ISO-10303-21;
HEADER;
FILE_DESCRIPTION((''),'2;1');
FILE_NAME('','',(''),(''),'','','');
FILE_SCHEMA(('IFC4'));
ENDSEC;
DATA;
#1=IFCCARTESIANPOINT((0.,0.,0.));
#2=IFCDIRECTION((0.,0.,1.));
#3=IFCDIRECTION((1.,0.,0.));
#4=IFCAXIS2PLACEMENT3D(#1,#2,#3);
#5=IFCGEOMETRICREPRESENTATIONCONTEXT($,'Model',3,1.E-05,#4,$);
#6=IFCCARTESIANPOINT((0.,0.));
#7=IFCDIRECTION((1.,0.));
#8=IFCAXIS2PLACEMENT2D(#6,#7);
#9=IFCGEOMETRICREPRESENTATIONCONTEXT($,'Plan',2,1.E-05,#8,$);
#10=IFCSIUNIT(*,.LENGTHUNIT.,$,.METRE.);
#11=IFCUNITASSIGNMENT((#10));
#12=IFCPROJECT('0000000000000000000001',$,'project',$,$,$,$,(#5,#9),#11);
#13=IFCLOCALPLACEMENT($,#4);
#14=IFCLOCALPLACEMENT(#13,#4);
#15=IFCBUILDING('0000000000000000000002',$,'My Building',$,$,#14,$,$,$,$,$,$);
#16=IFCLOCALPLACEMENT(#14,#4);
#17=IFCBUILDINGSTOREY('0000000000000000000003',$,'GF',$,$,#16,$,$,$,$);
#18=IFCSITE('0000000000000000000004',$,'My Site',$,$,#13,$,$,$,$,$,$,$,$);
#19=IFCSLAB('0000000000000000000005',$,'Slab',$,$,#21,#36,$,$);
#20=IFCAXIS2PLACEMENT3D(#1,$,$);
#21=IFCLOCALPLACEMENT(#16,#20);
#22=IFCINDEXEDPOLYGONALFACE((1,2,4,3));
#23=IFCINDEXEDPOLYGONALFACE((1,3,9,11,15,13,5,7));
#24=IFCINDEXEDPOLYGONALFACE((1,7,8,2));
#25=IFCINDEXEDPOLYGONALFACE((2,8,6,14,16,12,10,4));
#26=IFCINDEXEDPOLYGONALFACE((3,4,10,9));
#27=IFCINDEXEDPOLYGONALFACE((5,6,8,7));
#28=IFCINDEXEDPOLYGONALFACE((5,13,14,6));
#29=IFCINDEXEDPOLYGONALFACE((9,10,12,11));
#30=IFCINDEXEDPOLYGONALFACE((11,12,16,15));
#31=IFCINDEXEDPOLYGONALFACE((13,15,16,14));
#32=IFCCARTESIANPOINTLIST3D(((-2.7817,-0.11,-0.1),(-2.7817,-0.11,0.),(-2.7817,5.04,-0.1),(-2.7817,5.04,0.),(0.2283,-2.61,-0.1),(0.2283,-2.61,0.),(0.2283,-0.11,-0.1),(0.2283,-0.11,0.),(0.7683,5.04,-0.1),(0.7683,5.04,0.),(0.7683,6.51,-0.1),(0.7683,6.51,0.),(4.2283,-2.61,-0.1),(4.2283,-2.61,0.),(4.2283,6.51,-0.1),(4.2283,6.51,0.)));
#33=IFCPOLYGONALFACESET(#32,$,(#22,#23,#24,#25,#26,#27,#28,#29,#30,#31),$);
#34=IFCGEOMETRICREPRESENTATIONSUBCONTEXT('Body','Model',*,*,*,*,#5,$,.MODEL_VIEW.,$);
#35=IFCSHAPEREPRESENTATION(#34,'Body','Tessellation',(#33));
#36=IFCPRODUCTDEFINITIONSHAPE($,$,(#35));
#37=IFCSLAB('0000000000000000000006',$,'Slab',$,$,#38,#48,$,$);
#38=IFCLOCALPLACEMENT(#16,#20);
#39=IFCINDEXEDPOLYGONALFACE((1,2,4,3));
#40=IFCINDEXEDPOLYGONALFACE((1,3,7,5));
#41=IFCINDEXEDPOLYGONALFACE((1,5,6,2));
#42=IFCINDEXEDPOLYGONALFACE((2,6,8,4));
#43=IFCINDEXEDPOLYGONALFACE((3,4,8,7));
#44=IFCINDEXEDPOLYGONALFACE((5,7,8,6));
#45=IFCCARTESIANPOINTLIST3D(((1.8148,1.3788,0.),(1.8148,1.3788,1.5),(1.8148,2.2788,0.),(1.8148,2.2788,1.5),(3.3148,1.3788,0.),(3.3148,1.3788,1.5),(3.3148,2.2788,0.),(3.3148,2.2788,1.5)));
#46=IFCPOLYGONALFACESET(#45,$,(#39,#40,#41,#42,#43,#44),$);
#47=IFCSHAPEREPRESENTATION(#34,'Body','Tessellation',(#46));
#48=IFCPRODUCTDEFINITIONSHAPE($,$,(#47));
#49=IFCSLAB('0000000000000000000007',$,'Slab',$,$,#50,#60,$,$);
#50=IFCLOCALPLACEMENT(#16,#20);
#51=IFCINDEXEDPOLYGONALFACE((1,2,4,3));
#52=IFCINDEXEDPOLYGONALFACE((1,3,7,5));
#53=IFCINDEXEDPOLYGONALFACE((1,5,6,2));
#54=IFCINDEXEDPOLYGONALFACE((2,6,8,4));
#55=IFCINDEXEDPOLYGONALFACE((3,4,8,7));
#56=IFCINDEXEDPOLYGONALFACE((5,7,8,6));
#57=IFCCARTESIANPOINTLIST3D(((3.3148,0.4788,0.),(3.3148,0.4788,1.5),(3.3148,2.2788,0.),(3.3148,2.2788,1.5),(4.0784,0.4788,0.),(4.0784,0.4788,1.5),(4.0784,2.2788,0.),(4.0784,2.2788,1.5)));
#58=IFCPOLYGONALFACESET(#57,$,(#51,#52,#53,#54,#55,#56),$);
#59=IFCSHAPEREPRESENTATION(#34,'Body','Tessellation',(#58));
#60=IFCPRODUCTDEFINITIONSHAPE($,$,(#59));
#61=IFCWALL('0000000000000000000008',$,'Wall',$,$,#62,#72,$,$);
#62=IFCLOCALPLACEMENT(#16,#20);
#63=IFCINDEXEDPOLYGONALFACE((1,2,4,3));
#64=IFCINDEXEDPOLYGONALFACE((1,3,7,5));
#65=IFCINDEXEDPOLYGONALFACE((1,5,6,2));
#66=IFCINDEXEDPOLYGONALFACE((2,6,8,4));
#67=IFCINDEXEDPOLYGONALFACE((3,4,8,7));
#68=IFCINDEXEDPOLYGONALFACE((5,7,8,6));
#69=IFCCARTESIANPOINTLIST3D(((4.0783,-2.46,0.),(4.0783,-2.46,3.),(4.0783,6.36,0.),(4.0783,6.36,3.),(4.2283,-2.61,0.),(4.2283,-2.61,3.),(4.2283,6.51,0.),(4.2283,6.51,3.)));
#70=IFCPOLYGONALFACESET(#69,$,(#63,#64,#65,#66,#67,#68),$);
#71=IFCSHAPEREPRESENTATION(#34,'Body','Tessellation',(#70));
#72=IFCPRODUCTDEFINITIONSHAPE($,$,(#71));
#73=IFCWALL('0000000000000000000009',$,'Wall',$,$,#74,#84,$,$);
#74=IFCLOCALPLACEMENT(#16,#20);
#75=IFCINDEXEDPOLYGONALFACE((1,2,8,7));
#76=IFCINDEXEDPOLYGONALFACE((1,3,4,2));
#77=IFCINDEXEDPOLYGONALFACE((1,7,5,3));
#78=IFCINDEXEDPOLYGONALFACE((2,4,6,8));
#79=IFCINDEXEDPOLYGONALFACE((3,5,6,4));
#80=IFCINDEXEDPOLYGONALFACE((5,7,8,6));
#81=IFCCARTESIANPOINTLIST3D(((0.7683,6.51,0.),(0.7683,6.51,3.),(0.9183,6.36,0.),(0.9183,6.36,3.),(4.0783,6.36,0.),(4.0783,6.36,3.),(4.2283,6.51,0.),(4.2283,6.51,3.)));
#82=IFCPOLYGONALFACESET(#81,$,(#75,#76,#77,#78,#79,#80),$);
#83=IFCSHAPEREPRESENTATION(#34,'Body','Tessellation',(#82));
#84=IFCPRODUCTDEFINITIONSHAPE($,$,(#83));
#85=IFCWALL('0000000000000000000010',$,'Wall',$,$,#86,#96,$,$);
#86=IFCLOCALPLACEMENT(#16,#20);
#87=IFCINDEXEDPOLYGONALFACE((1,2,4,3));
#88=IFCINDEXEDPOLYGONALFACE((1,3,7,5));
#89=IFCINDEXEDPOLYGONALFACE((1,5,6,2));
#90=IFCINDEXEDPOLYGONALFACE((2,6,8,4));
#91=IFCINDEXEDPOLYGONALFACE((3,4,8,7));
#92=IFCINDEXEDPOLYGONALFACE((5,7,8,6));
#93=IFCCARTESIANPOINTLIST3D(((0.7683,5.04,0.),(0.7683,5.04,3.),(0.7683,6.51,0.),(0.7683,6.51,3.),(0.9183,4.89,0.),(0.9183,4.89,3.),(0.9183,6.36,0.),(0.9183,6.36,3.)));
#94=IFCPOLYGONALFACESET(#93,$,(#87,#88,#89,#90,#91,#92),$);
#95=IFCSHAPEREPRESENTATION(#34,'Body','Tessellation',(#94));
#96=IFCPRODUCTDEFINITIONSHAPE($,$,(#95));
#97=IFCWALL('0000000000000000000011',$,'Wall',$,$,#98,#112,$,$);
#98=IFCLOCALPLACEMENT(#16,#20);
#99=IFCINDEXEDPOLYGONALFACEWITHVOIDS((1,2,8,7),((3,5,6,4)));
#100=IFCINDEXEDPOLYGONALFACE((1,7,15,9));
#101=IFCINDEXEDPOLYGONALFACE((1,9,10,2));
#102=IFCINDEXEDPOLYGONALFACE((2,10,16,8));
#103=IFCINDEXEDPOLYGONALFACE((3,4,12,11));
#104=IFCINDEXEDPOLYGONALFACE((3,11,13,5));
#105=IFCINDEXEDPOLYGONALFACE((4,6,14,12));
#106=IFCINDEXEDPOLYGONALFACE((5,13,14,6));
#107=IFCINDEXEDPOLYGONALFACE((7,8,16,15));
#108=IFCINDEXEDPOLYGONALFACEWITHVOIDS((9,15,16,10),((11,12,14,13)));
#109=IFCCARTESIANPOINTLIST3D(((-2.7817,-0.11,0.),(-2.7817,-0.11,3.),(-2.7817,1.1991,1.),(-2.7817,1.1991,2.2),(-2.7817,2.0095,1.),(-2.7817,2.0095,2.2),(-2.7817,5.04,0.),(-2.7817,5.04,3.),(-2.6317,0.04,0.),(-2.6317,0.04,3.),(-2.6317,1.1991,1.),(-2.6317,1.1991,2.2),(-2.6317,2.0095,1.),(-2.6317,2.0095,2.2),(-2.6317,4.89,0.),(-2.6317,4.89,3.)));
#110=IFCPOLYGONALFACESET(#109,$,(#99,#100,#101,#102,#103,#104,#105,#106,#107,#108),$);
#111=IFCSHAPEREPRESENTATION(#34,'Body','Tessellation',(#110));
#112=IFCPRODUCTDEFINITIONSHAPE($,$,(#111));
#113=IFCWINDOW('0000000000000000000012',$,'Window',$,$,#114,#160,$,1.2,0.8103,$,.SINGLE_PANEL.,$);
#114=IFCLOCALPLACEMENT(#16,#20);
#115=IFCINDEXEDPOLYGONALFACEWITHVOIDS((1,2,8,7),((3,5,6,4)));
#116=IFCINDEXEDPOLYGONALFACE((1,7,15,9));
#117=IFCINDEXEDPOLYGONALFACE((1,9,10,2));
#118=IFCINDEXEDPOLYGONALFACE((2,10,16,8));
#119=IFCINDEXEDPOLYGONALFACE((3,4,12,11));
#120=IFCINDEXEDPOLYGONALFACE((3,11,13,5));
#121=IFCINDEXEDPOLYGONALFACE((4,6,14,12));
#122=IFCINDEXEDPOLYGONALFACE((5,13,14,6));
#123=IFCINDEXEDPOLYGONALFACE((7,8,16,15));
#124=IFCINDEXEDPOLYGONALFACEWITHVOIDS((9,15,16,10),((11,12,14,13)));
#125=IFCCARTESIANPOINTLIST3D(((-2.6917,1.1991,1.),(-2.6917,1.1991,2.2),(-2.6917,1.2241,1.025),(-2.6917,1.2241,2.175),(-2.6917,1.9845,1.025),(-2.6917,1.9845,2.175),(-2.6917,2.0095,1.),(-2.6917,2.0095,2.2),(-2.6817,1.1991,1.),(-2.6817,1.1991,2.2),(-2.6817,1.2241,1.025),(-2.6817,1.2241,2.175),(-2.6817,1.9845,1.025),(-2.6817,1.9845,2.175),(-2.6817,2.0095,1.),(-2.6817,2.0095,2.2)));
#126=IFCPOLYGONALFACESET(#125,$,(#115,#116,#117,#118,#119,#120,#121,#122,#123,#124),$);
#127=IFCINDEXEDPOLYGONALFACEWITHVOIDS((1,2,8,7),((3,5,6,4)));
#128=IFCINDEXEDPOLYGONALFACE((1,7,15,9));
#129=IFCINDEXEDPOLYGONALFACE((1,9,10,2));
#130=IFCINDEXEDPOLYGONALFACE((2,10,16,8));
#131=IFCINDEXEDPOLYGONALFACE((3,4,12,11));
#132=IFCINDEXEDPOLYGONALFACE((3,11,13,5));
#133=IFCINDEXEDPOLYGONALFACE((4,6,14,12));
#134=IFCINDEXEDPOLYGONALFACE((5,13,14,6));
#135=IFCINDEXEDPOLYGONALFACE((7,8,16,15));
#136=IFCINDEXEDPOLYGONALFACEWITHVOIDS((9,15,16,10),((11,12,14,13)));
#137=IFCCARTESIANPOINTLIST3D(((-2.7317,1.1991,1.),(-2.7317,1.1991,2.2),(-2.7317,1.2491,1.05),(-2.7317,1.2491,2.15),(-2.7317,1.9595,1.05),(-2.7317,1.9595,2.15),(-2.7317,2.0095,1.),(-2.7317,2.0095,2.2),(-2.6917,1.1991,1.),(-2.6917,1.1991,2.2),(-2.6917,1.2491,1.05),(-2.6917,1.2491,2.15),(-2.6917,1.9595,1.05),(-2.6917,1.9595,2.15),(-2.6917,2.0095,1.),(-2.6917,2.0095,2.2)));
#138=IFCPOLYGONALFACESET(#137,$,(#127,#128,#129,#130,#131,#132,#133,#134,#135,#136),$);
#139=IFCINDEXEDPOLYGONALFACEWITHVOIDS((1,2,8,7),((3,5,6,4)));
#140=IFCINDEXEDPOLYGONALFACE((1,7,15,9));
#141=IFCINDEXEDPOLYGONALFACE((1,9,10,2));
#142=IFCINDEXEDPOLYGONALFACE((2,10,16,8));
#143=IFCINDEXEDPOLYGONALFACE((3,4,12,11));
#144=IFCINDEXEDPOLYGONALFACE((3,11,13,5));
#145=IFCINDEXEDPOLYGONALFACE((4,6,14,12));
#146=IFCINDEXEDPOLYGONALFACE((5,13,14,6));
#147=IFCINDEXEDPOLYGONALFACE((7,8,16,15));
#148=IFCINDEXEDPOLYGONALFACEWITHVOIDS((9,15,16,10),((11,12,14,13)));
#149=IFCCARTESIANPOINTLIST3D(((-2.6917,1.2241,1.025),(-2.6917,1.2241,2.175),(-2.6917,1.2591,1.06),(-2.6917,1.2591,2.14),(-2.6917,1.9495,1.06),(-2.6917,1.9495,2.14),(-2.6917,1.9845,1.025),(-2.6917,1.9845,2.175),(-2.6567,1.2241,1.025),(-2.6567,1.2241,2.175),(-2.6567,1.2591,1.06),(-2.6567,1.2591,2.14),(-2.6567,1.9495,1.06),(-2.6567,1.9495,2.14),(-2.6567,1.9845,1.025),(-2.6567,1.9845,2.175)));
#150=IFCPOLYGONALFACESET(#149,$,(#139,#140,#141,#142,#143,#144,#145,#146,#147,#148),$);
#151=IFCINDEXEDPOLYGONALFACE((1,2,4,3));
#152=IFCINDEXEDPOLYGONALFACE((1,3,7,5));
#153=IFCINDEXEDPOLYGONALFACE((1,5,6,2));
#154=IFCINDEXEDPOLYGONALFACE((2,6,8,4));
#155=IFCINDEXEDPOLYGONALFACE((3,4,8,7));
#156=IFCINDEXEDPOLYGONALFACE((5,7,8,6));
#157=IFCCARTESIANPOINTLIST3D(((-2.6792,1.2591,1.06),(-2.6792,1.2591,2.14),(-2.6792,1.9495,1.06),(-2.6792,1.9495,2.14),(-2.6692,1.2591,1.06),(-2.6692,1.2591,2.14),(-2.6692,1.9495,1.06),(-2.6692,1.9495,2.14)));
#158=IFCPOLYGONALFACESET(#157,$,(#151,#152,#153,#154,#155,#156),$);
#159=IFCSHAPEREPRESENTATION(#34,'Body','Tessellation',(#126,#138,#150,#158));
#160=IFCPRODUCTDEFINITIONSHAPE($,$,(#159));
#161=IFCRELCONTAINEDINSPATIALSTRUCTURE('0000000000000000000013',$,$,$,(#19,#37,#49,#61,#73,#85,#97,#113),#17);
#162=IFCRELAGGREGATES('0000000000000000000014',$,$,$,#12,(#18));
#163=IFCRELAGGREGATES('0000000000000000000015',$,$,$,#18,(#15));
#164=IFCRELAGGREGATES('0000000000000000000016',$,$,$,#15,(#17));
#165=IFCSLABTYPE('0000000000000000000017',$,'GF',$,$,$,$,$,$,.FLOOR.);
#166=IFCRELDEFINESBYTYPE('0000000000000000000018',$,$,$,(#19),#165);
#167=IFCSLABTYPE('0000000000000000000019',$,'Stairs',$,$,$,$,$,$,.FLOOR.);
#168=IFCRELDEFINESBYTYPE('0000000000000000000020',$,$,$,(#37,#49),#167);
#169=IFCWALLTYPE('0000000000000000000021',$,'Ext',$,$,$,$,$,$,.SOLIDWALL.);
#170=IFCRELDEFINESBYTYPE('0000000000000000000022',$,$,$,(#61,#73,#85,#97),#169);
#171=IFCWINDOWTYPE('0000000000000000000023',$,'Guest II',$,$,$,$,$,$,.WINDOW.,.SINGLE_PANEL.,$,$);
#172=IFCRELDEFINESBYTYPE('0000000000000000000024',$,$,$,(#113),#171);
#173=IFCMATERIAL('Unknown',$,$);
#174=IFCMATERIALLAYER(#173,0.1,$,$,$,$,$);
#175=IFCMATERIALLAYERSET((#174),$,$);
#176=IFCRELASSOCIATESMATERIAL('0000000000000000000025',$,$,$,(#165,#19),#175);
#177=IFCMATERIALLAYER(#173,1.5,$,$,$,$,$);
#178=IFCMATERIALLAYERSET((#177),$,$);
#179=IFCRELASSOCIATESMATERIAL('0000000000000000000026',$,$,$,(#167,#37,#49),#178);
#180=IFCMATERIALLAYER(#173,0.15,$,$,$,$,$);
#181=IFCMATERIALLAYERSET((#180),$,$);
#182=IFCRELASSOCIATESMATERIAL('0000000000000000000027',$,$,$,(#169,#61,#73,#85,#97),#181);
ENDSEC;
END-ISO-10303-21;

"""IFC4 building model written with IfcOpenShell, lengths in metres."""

from ifc_helpers import new_model, entity, si_unit, frame, origin_with_axes, origin_2d_with_axis, place, context, subcontext, project, spatial, line, indexed_curve, outline, extrude, shape, source, transform, mapped, material, layer, layer_set, layer_usage, type_object, type_shapes, element, fill, save


model = new_model("IFC4")

# Units and contexts
model_context = context("Model", 3, precision=1e-05, world=origin_with_axes())
plan_context = context("Plan", 2, precision=1e-05, world=origin_2d_with_axis())
body_context_1 = subcontext(model_context, "Body", "Model", "MODEL_VIEW")
body_context_2 = subcontext(plan_context, "Body", "Plan", "PLAN_VIEW")
ifc_project = project(units=[si_unit("LENGTHUNIT", "METRE")], contexts=[model_context, plan_context])

# Site, building, storey
site_placement = place(None, origin_with_axes())
site = spatial("IfcSite", under=ifc_project, at=site_placement, Name="My Site")
building_placement = place(site_placement, origin_with_axes())
building = spatial("IfcBuilding", under=site, at=building_placement, Name="My Building")
storey_placement = place(building_placement, origin_with_axes())
storey = spatial("IfcBuildingStorey", under=building, at=storey_placement, Name="GF")

# Slabs
ifc_material = material(Name="Unknown")
ifc_layer_1 = layer(ifc_material, 0.1)
ifc_layer_set_1 = layer_set([ifc_layer_1])
ifc_layer_usage_1 = layer_usage(ifc_layer_set_1, "AXIS3", "POSITIVE", -0.1)
slab_type_1 = type_object("IfcSlabType", Name="GF", PredefinedType="FLOOR", material=ifc_layer_set_1)
slab_1_placement = place(storey_placement, frame((-2.7817, 5.04, 0.0), z_axis=(0.0, 0.0, 1.0), x_axis=(1.0, 0.0, 0.0)))
element("IfcSlab", 1, at=slab_1_placement, inside=storey, type_object=slab_type_1, material=ifc_layer_usage_1, Name="Slab", context=body_context_1, shape_type="SweptSolid", body=[
    extrude(outline(indexed_curve([(0.0, 0.0), (3.55, 0.0), (3.55, 1.47), (7.01, 1.47), (7.01, -7.65), (3.01, -7.65), (3.01, -5.15), (0.0, -5.15), (0.0, 0.0)])), frame((0.0, 0.0, -0.1), z_axis=(0.0, 0.0, 1.0), x_axis=(1.0, 0.0, 0.0)), (0.0, 0.0, 1.0), 0.1),
])
ifc_layer_2 = layer(ifc_material, 1.5)
ifc_layer_set_2 = layer_set([ifc_layer_2])
ifc_layer_usage_2 = layer_usage(ifc_layer_set_2, "AXIS3", "POSITIVE", -1.5)
slab_type_2 = type_object("IfcSlabType", Name="Stairs", PredefinedType="FLOOR", material=ifc_layer_set_2)
slab_2_placement = place(storey_placement, frame((3.3148, 2.2788, 1.5), z_axis=(0.0, 0.0, 1.0), x_axis=(1.0, 0.0, 0.0)))
element("IfcSlab", 2, at=slab_2_placement, inside=storey, type_object=slab_type_2, material=ifc_layer_usage_2, Name="Slab", context=body_context_1, shape_type="SweptSolid", body=[
    extrude(outline(indexed_curve([(0.0, 0.0), (0.0, -0.9), (-1.5, -0.9), (-1.5, 0.0), (0.0, 0.0)])), frame((0.0, 0.0, -1.5), z_axis=(0.0, 0.0, 1.0), x_axis=(1.0, 0.0, 0.0)), (0.0, 0.0, 1.0), 1.5),
])
ifc_layer_usage_3 = layer_usage(ifc_layer_set_2, "AXIS3", "POSITIVE", -1.5)
slab_3_placement = place(storey_placement, frame((3.3148, 0.4788, 1.5), z_axis=(0.0, 0.0, 1.0), x_axis=(1.0, 0.0, 0.0)))
element("IfcSlab", 3, at=slab_3_placement, inside=storey, type_object=slab_type_2, material=ifc_layer_usage_3, Name="Slab", context=body_context_1, shape_type="SweptSolid", body=[
    extrude(outline(indexed_curve([(0.0, 0.0), (0.7636, 0.0), (0.7636, 1.8), (0.0, 1.8), (0.0, 0.0)])), frame((0.0, 0.0, -1.5), z_axis=(0.0, 0.0, 1.0), x_axis=(1.0, 0.0, 0.0)), (0.0, 0.0, 1.0), 1.5),
])

# Shared definitions
ifc_layer_3 = layer(ifc_material, 0.15)
ifc_layer_set_3 = layer_set([ifc_layer_3])
wall_type_1 = type_object("IfcWallType", Name="Ext", PredefinedType="SOLIDWALL", material=ifc_layer_set_3)

# Walls
ifc_layer_usage_4 = layer_usage(ifc_layer_set_3, "AXIS2", "POSITIVE", 0.0)
wall_1_placement = place(storey_placement, frame((4.2283, -2.61, 0.0), z_axis=(0.0, 0.0, 1.0), x_axis=(0.0, 1.0, 0.0)))
element("IfcWall", 4, at=wall_1_placement, inside=storey, type_object=wall_type_1, material=ifc_layer_usage_4, Name="Wall", context=body_context_1, shape_type="SweptSolid", body=[
    extrude(outline(indexed_curve([(0.0, 0.0), (0.15, 0.15), (8.97, 0.15), (9.12, 0.0)], segments=[line(1, 2, 3, 4, 1)])), origin_with_axes(), (0.0, 0.0, 1.0), 3.0),
])
ifc_layer_usage_5 = layer_usage(ifc_layer_set_3, "AXIS2", "POSITIVE", 0.0)
wall_2_placement = place(storey_placement, frame((4.2283, 6.51, 0.0), z_axis=(0.0, 0.0, 1.0), x_axis=(-1.0, 0.0, 0.0)))
element("IfcWall", 5, at=wall_2_placement, inside=storey, type_object=wall_type_1, material=ifc_layer_usage_5, Name="Wall", context=body_context_1, shape_type="SweptSolid", body=[
    extrude(outline(indexed_curve([(0.0, 0.0), (0.15, 0.15), (3.31, 0.15), (3.46, 0.0)], segments=[line(1, 2, 3, 4, 1)])), origin_with_axes(), (0.0, 0.0, 1.0), 3.0),
])
ifc_layer_usage_6 = layer_usage(ifc_layer_set_3, "AXIS2", "POSITIVE", 0.0)
wall_3_placement = place(storey_placement, frame((0.7683, 6.51, 0.0), z_axis=(0.0, 0.0, 1.0), x_axis=(0.0, -1.0, 0.0)))
element("IfcWall", 6, at=wall_3_placement, inside=storey, type_object=wall_type_1, material=ifc_layer_usage_6, Name="Wall", context=body_context_1, shape_type="SweptSolid", body=[
    extrude(outline(indexed_curve([(0.0, 0.0), (0.15, 0.15), (1.62, 0.15), (1.47, 0.0)], segments=[line(1, 2, 3, 4, 1)])), origin_with_axes(), (0.0, 0.0, 1.0), 3.0),
])

# Wall, opening, window
ifc_layer_usage_7 = layer_usage(ifc_layer_set_3, "AXIS2", "POSITIVE", 0.0)
wall_4_placement = place(storey_placement, frame((-2.7817, 5.04, 0.0), z_axis=(0.0, 0.0, 1.0), x_axis=(0.0, -1.0, 0.0)))
wall_4 = element("IfcWall", 7, at=wall_4_placement, inside=storey, type_object=wall_type_1, material=ifc_layer_usage_7, Name="Wall", context=body_context_1, shape_type="SweptSolid", body=[
    extrude(outline(indexed_curve([(0.0, 0.0), (0.15, 0.15), (5.0, 0.15), (5.15, 0.0)], segments=[line(1, 2, 3, 4, 1)])), origin_with_axes(), (0.0, 0.0, 1.0), 3.0),
])
shared_shape_1 = source(origin_with_axes(), body_context_1, "Body", "SweptSolid", [
    extrude(outline(indexed_curve([(0.0, 0.0), (0.8103, 0.0), (0.8103, 1.2), (0.0, 1.2)], segments=[line(1, 2, 3, 4, 1)])), frame((0.0, -0.6, 0.0), z_axis=(0.0, -1.0, 0.0), x_axis=(1.0, 0.0, 0.0)), (0.0, 0.0, -1.0), 1.2),
])
opening_1_placement = place(wall_4_placement, frame((3.0305, 0.0, 1.0), z_axis=(0.0, 0.0, 1.0), x_axis=(1.0, 0.0, 0.0)))
opening_1 = element("IfcOpeningElement", 8, at=opening_1_placement, cuts=wall_4, PredefinedType="OPENING", context=body_context_1, shape_type="MappedRepresentation", body=[
    mapped(shared_shape_1, transform((0.0, 0.0, 0.0), x_axis=(1.0, 0.0, 0.0), y_axis=(0.0, 1.0, 0.0), z_axis=(0.0, 0.0, 1.0), scale=1.0)),
])
window_type_1 = type_object("IfcWindowType", Name="Guest II", PartitioningType="SINGLE_PANEL", PredefinedType="WINDOW")
shared_shape_2 = source(origin_with_axes(), body_context_1, "Body", "SweptSolid", [
    extrude(outline(indexed_curve([(0.0, 0.0), (0.8103, 0.0), (0.8103, 1.2), (0.0, 1.2)], segments=[line(1, 2, 3, 4, 1)]), holes=[indexed_curve([(0.025, 0.025), (0.7853, 0.025), (0.7853, 1.175), (0.025, 1.175)], segments=[line(1, 2, 3, 4, 1)])]), frame((0.0, 0.09, 0.0), z_axis=(0.0, -1.0, 0.0), x_axis=(1.0, 0.0, 0.0)), (0.0, 0.0, -1.0), 0.01),
    extrude(outline(indexed_curve([(0.0, 0.0), (0.8103, 0.0), (0.8103, 1.2), (0.0, 1.2)], segments=[line(1, 2, 3, 4, 1)]), holes=[indexed_curve([(0.05, 0.05), (0.7603, 0.05), (0.7603, 1.15), (0.05, 1.15)], segments=[line(1, 2, 3, 4, 1)])]), frame((0.0, 0.05, 0.0), z_axis=(0.0, -1.0, 0.0), x_axis=(1.0, 0.0, 0.0)), (0.0, 0.0, -1.0), 0.04),
    extrude(outline(indexed_curve([(0.0, 0.0), (0.7603, 0.0), (0.7603, 1.15), (0.0, 1.15)], segments=[line(1, 2, 3, 4, 1)]), holes=[indexed_curve([(0.035, 0.035), (0.7253, 0.035), (0.7253, 1.115), (0.035, 1.115)], segments=[line(1, 2, 3, 4, 1)])]), frame((0.025, 0.09, 0.025), z_axis=(0.0, -1.0, 0.0), x_axis=(1.0, 0.0, 0.0)), (0.0, 0.0, -1.0), 0.035),
    extrude(outline(indexed_curve([(0.035, 0.035), (0.7253, 0.035), (0.7253, 1.115), (0.035, 1.115)], segments=[line(1, 2, 3, 4, 1)])), frame((0.025, 0.1025, 0.025), z_axis=(0.0, -1.0, 0.0), x_axis=(1.0, 0.0, 0.0)), (0.0, 0.0, -1.0), 0.01),
])
shared_shape_3 = source(origin_with_axes(), body_context_2, "Body", "Curve2D", [
    entity("IfcIndexedPolyCurve", entity("IfcCartesianPointList2D", [[0.05, 0.05], [0.7603, 0.05]])),
    entity("IfcIndexedPolyCurve", entity("IfcCartesianPointList2D", [[0.0, 0.1], [0.025, 0.1], [0.025, 0.09], [0.05, 0.09], [0.05, 0.05], [0.0, 0.05]]), [entity("IfcLineIndex", [1, 2, 3, 4, 5, 6, 1])]),
    entity("IfcIndexedPolyCurve", entity("IfcCartesianPointList2D", [[0.8103, 0.1], [0.7853, 0.1], [0.7853, 0.09], [0.7603, 0.09], [0.7603, 0.05], [0.8103, 0.05]]), [entity("IfcLineIndex", [1, 2, 3, 4, 5, 6, 1])]),
    entity("IfcIndexedPolyCurve", entity("IfcCartesianPointList2D", [[0.025, 0.09], [0.06, 0.09], [0.06, 0.125], [0.025, 0.125]]), [entity("IfcLineIndex", [1, 2, 3, 4, 1])]),
    entity("IfcIndexedPolyCurve", entity("IfcCartesianPointList2D", [[0.7853, 0.09], [0.7503, 0.09], [0.7503, 0.125], [0.7853, 0.125]]), [entity("IfcLineIndex", [1, 2, 3, 4, 1])]),
    entity("IfcIndexedPolyCurve", entity("IfcCartesianPointList2D", [[0.06, 0.09], [0.7503, 0.09]])),
    entity("IfcIndexedPolyCurve", entity("IfcCartesianPointList2D", [[0.06, 0.125], [0.7503, 0.125]])),
    entity("IfcIndexedPolyCurve", entity("IfcCartesianPointList2D", [[0.06, 0.1075], [0.7503, 0.1075]])),
])
type_shapes(window_type_1, [shared_shape_2, shared_shape_3])
window_1_placement = place(opening_1_placement, frame((0.0, 0.0, 0.0), z_axis=(0.0, 0.0, 1.0), x_axis=(1.0, 0.0, 0.0)))
window_1 = element("IfcWindow", 9, at=window_1_placement, inside=storey, type_object=window_type_1, Name="Window", OverallHeight=1.2, OverallWidth=0.8103, PartitioningType="SINGLE_PANEL", shapes=[
    shape(body_context_1, "Body", "MappedRepresentation", [mapped(shared_shape_2, transform((0.0, 0.0, 0.0), x_axis=(1.0, 0.0, 0.0), y_axis=(0.0, 1.0, 0.0), z_axis=(0.0, 0.0, 1.0), scale=1.0))]),
    shape(body_context_2, "Body", "MappedRepresentation", [mapped(shared_shape_3, transform((0.0, 0.0, 0.0), x_axis=(1.0, 0.0, 0.0), y_axis=(0.0, 1.0, 0.0), z_axis=(0.0, 0.0, 1.0), scale=1.0))]),
])
fill(opening_1, window_1)

save(model, "model.ifc")
